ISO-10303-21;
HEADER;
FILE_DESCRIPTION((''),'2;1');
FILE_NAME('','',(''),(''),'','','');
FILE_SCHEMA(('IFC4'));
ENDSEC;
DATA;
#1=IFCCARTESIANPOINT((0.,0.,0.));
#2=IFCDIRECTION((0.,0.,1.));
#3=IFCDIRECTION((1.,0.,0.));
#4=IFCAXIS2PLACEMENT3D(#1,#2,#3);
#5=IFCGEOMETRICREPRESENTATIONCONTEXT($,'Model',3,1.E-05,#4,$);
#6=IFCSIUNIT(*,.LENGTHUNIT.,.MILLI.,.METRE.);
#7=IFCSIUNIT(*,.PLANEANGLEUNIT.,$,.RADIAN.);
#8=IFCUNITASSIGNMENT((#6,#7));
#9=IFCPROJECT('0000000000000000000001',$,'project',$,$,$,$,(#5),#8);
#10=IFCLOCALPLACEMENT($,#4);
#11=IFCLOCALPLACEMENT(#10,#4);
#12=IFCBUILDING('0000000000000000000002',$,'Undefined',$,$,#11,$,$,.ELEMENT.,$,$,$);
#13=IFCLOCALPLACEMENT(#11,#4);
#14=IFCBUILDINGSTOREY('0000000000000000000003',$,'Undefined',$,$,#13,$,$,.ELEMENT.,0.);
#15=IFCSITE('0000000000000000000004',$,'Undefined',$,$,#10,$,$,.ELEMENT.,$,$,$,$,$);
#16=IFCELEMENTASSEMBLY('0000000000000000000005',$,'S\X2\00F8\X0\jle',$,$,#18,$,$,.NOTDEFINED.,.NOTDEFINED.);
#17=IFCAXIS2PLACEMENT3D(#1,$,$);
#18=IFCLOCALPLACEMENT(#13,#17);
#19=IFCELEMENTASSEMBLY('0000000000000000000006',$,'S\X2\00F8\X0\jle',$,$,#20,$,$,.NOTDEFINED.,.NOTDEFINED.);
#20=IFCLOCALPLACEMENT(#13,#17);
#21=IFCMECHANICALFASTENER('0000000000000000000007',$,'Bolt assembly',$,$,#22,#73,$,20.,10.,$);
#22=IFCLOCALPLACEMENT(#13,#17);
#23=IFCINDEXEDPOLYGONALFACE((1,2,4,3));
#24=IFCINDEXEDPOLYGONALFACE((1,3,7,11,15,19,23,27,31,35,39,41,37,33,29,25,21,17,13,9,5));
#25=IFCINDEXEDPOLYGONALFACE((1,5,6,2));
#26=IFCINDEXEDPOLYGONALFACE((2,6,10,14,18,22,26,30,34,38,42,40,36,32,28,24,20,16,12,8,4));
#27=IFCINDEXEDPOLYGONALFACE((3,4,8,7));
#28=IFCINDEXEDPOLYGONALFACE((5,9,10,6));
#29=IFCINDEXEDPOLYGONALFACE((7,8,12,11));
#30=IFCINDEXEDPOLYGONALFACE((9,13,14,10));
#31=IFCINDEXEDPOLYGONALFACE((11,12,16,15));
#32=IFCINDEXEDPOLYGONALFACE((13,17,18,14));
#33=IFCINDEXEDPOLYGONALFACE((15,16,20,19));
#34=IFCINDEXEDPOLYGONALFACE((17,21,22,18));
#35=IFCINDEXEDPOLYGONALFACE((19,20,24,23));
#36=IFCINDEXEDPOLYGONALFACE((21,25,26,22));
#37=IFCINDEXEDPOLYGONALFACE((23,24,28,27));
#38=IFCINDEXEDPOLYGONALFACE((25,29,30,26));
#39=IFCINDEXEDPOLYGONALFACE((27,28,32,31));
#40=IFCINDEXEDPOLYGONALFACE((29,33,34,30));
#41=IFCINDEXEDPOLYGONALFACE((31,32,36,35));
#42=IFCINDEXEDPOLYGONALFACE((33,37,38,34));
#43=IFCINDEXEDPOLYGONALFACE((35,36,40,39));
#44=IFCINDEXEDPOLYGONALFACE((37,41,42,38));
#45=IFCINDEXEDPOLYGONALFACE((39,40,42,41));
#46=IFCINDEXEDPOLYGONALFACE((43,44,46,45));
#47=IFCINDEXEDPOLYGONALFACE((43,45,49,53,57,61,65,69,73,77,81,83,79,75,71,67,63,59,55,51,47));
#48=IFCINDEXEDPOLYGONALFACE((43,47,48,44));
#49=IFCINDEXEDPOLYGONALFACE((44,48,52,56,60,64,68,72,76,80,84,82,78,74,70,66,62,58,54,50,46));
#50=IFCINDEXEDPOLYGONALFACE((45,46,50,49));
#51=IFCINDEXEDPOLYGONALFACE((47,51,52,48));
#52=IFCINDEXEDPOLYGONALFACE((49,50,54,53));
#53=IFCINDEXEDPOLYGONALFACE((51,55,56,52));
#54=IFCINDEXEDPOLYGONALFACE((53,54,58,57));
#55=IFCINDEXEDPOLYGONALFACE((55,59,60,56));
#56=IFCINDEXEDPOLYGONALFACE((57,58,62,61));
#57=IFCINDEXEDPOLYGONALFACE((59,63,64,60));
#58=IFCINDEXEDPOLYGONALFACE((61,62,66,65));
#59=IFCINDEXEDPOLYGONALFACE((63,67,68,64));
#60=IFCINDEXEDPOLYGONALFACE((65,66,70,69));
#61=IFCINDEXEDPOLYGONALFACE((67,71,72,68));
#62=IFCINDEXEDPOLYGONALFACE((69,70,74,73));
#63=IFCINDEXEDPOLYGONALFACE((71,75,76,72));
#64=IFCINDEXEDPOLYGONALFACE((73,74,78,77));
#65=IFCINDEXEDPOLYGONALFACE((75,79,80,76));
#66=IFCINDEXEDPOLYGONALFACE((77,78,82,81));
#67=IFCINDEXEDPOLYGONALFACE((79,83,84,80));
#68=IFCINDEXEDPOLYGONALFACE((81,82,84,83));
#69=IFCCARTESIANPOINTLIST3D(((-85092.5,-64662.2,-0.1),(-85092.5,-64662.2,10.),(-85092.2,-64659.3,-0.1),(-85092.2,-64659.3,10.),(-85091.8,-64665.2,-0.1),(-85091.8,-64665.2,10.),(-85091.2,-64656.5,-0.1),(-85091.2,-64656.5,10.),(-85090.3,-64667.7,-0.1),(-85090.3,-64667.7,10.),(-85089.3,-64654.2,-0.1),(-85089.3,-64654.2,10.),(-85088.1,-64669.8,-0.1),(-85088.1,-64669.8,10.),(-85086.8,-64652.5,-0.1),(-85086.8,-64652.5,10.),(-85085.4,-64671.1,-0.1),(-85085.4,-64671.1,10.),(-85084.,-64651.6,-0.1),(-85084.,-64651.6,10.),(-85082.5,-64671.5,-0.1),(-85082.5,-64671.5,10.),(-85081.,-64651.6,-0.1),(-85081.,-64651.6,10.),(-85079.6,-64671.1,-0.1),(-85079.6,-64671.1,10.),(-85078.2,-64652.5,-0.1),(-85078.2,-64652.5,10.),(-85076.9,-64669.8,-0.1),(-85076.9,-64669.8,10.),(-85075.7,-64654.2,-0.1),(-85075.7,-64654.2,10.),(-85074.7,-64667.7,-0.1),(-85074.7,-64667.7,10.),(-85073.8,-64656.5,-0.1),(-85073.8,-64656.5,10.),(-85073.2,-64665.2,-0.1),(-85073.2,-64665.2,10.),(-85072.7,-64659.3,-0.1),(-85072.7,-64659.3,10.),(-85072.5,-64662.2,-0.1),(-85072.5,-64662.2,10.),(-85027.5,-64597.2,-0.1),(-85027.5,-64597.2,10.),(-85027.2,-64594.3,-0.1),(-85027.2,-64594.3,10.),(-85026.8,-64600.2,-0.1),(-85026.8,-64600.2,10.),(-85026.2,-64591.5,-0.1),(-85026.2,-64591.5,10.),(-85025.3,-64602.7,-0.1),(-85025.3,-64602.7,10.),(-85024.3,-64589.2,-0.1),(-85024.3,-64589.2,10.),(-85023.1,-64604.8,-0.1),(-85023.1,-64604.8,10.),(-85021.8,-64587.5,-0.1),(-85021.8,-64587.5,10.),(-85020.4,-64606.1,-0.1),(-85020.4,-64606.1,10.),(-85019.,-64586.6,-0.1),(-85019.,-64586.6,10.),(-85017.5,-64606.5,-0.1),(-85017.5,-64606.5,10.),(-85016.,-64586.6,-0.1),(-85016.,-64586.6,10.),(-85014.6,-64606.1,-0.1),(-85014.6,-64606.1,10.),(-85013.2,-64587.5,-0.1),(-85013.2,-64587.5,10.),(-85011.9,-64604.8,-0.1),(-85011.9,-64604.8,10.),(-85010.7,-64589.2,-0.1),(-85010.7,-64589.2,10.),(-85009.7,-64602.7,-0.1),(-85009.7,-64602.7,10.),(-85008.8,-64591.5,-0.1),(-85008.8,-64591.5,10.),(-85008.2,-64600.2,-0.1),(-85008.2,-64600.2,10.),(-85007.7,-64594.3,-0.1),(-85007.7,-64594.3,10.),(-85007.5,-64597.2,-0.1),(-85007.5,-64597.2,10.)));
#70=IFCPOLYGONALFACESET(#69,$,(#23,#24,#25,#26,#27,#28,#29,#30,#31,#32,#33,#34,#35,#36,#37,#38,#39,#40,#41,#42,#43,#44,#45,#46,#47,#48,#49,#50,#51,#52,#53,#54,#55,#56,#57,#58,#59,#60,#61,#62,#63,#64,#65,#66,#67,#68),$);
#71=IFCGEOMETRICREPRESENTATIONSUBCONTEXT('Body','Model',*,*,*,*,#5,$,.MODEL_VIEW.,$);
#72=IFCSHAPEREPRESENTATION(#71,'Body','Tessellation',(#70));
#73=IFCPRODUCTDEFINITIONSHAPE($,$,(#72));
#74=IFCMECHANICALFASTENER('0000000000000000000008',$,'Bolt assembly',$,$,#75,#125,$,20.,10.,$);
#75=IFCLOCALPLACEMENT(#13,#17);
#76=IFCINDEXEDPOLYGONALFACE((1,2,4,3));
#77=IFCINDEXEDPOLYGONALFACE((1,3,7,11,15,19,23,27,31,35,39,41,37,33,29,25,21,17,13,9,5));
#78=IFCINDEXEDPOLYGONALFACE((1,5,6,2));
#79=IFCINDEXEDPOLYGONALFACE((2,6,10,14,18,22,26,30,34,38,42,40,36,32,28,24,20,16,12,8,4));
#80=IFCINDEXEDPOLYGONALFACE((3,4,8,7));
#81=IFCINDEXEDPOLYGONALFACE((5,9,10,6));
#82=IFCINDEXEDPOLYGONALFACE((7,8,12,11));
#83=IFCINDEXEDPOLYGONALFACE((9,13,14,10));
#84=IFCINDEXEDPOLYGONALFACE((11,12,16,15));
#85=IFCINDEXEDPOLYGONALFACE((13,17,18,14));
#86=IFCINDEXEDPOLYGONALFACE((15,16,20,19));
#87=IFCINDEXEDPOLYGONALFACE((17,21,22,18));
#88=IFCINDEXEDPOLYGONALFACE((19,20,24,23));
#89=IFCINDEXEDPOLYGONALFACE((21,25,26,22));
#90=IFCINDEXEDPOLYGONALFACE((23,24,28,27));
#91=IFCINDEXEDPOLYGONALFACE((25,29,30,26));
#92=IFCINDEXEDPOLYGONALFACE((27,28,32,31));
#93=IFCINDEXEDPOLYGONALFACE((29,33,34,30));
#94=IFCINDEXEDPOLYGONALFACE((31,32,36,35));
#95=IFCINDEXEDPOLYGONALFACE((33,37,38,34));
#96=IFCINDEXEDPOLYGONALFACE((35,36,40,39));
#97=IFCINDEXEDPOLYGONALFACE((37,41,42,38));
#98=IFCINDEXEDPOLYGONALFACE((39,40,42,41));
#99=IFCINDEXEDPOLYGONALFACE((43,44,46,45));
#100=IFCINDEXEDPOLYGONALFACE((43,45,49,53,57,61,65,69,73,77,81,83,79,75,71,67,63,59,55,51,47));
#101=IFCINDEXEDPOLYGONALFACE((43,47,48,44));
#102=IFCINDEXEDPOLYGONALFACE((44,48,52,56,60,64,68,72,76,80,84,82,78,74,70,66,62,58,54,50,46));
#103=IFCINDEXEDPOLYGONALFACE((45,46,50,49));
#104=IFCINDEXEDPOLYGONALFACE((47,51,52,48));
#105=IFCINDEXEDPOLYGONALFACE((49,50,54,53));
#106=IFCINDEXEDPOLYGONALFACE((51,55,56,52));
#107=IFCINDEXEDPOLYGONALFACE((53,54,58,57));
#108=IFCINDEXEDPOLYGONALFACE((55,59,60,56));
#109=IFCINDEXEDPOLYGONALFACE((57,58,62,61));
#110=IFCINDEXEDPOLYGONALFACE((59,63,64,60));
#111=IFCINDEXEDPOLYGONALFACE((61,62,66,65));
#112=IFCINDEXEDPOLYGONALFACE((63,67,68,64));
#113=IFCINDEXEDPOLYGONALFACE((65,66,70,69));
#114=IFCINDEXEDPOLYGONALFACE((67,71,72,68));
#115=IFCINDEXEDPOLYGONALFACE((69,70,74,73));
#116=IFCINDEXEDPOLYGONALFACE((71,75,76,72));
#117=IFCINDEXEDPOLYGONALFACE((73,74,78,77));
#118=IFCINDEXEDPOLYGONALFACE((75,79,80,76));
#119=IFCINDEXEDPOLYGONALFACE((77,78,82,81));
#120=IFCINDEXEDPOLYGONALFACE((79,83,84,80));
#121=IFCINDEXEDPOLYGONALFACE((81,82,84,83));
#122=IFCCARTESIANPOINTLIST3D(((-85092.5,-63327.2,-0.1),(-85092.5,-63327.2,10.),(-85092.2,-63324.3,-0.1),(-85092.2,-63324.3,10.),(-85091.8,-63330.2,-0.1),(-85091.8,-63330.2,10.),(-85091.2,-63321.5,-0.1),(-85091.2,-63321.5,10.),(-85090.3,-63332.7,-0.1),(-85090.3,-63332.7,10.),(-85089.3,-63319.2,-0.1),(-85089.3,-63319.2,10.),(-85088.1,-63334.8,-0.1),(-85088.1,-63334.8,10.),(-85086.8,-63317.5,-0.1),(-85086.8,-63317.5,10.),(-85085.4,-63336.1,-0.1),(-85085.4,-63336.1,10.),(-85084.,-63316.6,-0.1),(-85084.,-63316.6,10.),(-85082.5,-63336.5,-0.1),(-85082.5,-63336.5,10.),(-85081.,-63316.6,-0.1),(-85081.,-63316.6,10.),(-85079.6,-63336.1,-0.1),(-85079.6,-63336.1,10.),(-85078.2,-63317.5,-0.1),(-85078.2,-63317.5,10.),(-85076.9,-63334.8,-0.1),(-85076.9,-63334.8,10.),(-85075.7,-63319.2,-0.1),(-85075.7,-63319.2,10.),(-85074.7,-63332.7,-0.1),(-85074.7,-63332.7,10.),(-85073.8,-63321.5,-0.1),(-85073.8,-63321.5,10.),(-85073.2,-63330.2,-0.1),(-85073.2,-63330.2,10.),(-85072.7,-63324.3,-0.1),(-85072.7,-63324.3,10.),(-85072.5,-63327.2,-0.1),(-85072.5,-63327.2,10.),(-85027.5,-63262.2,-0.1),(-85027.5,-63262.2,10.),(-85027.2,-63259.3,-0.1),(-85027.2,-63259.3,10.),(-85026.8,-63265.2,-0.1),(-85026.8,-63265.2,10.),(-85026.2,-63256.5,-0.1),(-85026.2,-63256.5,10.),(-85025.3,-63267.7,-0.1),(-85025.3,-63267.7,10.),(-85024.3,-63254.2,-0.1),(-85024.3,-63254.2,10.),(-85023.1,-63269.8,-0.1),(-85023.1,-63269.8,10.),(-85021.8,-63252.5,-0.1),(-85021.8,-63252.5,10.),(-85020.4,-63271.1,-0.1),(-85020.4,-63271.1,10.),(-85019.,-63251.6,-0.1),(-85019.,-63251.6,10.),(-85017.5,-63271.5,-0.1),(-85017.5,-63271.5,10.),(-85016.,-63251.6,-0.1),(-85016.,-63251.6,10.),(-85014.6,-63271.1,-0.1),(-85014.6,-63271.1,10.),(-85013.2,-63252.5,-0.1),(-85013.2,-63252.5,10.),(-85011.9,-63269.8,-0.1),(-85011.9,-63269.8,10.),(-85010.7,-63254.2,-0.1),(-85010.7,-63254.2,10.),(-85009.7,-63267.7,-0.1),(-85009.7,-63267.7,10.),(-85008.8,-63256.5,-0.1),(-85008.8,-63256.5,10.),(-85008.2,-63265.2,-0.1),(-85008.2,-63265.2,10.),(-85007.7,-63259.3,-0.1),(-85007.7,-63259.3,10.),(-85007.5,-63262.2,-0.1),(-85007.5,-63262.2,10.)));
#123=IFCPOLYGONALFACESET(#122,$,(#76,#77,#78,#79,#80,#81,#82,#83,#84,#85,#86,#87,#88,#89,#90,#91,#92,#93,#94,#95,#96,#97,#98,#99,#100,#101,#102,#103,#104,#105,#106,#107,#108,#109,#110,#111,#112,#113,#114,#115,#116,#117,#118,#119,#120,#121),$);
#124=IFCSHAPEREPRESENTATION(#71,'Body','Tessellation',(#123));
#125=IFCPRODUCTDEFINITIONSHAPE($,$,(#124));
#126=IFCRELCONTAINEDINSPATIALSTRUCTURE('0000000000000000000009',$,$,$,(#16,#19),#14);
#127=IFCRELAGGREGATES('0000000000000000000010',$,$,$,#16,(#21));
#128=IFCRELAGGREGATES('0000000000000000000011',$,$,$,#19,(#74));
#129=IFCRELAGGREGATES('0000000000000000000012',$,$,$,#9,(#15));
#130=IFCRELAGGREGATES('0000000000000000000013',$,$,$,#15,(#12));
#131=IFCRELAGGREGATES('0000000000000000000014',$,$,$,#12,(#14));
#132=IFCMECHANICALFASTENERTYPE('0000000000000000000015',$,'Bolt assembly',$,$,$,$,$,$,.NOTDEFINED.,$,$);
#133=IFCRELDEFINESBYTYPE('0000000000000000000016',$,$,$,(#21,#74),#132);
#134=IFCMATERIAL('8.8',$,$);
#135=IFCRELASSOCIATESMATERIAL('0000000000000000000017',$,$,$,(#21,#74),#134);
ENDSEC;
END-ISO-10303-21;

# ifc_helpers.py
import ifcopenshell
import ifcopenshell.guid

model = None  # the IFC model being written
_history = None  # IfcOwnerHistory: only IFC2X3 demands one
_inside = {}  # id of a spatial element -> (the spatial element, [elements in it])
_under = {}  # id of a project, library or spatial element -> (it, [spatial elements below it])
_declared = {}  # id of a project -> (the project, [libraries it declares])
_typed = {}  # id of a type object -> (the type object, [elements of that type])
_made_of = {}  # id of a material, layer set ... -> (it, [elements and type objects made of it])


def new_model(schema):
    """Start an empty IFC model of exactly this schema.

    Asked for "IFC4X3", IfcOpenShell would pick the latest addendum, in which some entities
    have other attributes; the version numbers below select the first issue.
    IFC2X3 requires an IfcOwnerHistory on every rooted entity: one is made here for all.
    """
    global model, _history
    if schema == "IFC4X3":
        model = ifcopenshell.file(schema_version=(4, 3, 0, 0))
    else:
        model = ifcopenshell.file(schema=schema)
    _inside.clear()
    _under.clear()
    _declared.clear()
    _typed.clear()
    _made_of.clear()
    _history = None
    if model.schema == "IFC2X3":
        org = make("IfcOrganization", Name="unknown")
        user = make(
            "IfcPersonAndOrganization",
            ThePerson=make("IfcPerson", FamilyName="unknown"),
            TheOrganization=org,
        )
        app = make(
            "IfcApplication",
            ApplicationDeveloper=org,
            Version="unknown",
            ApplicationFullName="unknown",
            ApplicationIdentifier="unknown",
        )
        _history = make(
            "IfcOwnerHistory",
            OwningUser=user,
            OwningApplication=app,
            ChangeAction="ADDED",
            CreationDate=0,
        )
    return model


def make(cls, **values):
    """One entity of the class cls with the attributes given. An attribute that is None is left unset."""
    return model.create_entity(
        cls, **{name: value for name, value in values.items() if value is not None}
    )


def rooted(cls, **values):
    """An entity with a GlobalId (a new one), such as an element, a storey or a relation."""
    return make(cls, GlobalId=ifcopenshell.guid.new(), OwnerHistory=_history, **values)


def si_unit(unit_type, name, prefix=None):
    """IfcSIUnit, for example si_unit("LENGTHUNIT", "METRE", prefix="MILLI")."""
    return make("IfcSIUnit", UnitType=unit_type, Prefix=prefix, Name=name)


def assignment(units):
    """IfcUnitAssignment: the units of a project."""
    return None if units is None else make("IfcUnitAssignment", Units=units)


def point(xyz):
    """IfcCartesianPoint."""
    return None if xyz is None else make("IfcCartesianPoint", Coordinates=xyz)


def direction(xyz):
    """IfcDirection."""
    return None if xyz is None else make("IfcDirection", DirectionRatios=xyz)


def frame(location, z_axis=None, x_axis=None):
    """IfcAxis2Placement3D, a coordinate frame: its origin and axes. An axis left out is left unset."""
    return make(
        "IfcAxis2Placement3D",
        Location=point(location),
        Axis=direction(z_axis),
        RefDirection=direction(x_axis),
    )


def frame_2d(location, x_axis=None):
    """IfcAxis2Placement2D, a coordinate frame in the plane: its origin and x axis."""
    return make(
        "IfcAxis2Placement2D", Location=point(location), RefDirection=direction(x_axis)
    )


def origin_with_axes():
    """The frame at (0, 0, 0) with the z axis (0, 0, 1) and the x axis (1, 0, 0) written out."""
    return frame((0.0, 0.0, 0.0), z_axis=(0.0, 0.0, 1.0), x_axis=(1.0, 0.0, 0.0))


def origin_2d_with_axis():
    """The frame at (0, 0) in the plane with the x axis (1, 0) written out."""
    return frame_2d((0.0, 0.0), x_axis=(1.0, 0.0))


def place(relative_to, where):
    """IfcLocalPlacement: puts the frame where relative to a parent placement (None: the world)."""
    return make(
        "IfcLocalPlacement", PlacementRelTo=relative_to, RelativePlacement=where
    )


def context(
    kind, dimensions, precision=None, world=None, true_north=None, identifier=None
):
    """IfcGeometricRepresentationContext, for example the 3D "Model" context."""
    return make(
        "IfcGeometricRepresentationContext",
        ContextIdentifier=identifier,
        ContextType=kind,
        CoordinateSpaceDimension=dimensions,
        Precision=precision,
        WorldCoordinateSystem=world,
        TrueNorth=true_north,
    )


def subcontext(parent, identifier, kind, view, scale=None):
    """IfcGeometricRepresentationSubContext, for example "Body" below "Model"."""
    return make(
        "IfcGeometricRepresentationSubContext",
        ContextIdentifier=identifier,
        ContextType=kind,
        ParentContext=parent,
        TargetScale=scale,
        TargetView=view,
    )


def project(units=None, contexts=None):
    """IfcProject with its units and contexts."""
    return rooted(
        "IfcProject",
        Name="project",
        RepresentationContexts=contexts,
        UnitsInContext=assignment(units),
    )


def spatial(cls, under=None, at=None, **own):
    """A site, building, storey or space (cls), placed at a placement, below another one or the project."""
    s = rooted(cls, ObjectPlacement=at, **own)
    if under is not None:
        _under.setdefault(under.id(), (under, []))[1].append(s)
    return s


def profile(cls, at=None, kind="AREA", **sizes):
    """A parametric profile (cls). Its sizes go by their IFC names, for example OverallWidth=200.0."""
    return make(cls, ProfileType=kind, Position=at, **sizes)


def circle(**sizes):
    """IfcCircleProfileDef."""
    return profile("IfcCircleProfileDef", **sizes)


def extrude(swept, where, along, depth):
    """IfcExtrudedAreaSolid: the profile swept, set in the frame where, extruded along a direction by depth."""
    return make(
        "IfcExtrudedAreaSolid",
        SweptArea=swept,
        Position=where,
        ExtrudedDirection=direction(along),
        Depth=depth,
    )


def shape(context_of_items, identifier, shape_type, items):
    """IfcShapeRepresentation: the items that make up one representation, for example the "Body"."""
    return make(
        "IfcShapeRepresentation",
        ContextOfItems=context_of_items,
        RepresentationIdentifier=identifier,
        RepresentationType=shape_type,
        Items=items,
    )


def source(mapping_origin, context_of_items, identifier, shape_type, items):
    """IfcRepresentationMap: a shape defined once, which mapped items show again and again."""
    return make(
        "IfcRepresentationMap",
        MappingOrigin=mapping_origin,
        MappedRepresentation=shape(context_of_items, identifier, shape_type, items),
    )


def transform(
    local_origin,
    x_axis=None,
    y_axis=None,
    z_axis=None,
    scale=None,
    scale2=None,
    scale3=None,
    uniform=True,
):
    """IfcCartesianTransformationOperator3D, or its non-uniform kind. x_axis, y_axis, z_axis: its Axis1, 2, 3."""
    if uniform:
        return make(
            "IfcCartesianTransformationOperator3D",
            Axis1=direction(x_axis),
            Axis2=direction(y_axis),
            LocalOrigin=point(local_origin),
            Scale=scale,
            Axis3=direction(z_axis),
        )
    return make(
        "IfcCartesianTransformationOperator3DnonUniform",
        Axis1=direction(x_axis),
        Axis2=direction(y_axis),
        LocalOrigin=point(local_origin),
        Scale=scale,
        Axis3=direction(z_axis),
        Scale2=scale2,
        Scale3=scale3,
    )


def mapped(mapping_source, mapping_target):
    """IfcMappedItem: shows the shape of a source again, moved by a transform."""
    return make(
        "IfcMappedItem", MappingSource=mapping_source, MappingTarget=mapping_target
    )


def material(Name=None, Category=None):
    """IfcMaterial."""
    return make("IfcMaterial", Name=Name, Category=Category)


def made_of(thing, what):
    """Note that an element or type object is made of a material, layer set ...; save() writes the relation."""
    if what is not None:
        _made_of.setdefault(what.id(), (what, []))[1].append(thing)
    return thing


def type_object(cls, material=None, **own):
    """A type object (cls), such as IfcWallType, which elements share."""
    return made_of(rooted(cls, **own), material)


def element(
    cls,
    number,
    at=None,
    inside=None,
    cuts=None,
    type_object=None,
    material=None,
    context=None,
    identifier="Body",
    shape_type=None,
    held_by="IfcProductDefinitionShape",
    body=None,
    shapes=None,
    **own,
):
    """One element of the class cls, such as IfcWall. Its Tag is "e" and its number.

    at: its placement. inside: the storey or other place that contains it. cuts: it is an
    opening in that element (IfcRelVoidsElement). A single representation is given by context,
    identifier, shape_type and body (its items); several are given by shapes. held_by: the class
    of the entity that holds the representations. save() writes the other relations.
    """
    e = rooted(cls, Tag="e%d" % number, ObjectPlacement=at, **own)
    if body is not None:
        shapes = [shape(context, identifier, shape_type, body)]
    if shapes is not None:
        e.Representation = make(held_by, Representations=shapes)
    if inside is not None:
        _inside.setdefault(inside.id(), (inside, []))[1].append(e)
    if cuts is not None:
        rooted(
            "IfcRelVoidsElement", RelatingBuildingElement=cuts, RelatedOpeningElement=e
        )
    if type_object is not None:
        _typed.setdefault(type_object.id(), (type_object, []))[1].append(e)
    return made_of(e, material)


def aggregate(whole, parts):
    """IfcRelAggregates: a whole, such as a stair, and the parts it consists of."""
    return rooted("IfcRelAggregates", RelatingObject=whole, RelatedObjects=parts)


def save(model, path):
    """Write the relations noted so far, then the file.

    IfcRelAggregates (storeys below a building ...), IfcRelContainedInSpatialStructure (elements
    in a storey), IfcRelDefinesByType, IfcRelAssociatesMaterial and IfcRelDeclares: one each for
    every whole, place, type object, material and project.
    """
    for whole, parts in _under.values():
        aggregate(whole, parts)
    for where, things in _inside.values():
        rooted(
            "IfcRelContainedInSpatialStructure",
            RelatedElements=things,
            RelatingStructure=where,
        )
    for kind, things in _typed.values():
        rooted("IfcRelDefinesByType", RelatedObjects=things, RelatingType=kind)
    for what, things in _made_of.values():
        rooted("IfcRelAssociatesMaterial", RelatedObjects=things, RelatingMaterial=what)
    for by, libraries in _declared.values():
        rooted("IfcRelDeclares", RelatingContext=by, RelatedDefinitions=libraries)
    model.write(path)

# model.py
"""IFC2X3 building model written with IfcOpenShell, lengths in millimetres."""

from ifc_helpers import new_model, si_unit, frame, origin_with_axes, origin_2d_with_axis, place, context, subcontext, project, spatial, circle, extrude, source, transform, mapped, material, type_object, element, aggregate, save


model = new_model("IFC2X3")

# Units and contexts
model_context = context("Model", 3, precision=1e-05, world=origin_with_axes())
body_context = subcontext(model_context, "Body", "Model", "MODEL_VIEW")
ifc_project = project(units=[si_unit("LENGTHUNIT", "METRE", prefix="MILLI"), si_unit("PLANEANGLEUNIT", "RADIAN")], contexts=[model_context])

# Site, building, storey
site_placement = place(None, origin_with_axes())
site = spatial("IfcSite", under=ifc_project, at=site_placement, Name="Undefined", CompositionType="ELEMENT")
building_placement = place(site_placement, origin_with_axes())
building = spatial("IfcBuilding", under=site, at=building_placement, Name="Undefined", CompositionType="ELEMENT")
storey_placement = place(building_placement, origin_with_axes())
storey = spatial("IfcBuildingStorey", under=building, at=storey_placement, Name="Undefined", CompositionType="ELEMENT", Elevation=0.0)

# Shared definitions
ifc_material_1 = material(Name="8.8")
mechanical_fastener_type = type_object("IfcMechanicalFastenerType", Name="Bolt assembly")
shared_shape_1 = source(origin_with_axes(), body_context, "Body", "SweptSolid", [
    extrude(circle(Radius=10.0, at=origin_2d_with_axis()), frame((0.0, 0.0, 0.0), z_axis=(0.0, 1.0, 0.0), x_axis=(1.0, 0.0, 0.0)), (0.0, 0.0, 1.0), 10.1),
])

# Element assemblies
assembly_1_placement = place(storey_placement, origin_with_axes())
assembly_1 = element("IfcElementAssembly", 1, at=assembly_1_placement, inside=storey, Name="Søjle", AssemblyPlace="NOTDEFINED", PredefinedType="NOTDEFINED")
assembly_2_placement = place(storey_placement, origin_with_axes())
assembly_2 = element("IfcElementAssembly", 2, at=assembly_2_placement, inside=storey, Name="Søjle", AssemblyPlace="NOTDEFINED", PredefinedType="NOTDEFINED")

# Mechanical fasteners
mechanical_fastener_1_placement = place(assembly_1_placement, frame((-85050.0, -64596.5, 10.0), z_axis=(1.0, 0.0, 0.0), x_axis=(0.0, -1.0, 0.0)))
mechanical_fastener_1 = element("IfcMechanicalFastener", 3, at=mechanical_fastener_1_placement, type_object=mechanical_fastener_type, material=ifc_material_1, Name="Bolt assembly", NominalDiameter=20.0, NominalLength=10.0, context=body_context, shape_type="MappedRepresentation", body=[
    mapped(shared_shape_1, transform((65.0, 0.0, -32.5))),
    mapped(shared_shape_1, transform((0.0, 0.0, 32.5))),
])
mechanical_fastener_2_placement = place(assembly_2_placement, frame((-85050.0, -63261.5, 10.0), z_axis=(1.0, 0.0, 0.0), x_axis=(0.0, -1.0, 0.0)))
mechanical_fastener_2 = element("IfcMechanicalFastener", 4, at=mechanical_fastener_2_placement, type_object=mechanical_fastener_type, material=ifc_material_1, Name="Bolt assembly", NominalDiameter=20.0, NominalLength=10.0, context=body_context, shape_type="MappedRepresentation", body=[
    mapped(shared_shape_1, transform((65.0, 0.0, -32.5))),
    mapped(shared_shape_1, transform((0.0, 0.0, 32.5))),
])
aggregate(assembly_1, [mechanical_fastener_1])
aggregate(assembly_2, [mechanical_fastener_2])

save(model, "model.ifc")
